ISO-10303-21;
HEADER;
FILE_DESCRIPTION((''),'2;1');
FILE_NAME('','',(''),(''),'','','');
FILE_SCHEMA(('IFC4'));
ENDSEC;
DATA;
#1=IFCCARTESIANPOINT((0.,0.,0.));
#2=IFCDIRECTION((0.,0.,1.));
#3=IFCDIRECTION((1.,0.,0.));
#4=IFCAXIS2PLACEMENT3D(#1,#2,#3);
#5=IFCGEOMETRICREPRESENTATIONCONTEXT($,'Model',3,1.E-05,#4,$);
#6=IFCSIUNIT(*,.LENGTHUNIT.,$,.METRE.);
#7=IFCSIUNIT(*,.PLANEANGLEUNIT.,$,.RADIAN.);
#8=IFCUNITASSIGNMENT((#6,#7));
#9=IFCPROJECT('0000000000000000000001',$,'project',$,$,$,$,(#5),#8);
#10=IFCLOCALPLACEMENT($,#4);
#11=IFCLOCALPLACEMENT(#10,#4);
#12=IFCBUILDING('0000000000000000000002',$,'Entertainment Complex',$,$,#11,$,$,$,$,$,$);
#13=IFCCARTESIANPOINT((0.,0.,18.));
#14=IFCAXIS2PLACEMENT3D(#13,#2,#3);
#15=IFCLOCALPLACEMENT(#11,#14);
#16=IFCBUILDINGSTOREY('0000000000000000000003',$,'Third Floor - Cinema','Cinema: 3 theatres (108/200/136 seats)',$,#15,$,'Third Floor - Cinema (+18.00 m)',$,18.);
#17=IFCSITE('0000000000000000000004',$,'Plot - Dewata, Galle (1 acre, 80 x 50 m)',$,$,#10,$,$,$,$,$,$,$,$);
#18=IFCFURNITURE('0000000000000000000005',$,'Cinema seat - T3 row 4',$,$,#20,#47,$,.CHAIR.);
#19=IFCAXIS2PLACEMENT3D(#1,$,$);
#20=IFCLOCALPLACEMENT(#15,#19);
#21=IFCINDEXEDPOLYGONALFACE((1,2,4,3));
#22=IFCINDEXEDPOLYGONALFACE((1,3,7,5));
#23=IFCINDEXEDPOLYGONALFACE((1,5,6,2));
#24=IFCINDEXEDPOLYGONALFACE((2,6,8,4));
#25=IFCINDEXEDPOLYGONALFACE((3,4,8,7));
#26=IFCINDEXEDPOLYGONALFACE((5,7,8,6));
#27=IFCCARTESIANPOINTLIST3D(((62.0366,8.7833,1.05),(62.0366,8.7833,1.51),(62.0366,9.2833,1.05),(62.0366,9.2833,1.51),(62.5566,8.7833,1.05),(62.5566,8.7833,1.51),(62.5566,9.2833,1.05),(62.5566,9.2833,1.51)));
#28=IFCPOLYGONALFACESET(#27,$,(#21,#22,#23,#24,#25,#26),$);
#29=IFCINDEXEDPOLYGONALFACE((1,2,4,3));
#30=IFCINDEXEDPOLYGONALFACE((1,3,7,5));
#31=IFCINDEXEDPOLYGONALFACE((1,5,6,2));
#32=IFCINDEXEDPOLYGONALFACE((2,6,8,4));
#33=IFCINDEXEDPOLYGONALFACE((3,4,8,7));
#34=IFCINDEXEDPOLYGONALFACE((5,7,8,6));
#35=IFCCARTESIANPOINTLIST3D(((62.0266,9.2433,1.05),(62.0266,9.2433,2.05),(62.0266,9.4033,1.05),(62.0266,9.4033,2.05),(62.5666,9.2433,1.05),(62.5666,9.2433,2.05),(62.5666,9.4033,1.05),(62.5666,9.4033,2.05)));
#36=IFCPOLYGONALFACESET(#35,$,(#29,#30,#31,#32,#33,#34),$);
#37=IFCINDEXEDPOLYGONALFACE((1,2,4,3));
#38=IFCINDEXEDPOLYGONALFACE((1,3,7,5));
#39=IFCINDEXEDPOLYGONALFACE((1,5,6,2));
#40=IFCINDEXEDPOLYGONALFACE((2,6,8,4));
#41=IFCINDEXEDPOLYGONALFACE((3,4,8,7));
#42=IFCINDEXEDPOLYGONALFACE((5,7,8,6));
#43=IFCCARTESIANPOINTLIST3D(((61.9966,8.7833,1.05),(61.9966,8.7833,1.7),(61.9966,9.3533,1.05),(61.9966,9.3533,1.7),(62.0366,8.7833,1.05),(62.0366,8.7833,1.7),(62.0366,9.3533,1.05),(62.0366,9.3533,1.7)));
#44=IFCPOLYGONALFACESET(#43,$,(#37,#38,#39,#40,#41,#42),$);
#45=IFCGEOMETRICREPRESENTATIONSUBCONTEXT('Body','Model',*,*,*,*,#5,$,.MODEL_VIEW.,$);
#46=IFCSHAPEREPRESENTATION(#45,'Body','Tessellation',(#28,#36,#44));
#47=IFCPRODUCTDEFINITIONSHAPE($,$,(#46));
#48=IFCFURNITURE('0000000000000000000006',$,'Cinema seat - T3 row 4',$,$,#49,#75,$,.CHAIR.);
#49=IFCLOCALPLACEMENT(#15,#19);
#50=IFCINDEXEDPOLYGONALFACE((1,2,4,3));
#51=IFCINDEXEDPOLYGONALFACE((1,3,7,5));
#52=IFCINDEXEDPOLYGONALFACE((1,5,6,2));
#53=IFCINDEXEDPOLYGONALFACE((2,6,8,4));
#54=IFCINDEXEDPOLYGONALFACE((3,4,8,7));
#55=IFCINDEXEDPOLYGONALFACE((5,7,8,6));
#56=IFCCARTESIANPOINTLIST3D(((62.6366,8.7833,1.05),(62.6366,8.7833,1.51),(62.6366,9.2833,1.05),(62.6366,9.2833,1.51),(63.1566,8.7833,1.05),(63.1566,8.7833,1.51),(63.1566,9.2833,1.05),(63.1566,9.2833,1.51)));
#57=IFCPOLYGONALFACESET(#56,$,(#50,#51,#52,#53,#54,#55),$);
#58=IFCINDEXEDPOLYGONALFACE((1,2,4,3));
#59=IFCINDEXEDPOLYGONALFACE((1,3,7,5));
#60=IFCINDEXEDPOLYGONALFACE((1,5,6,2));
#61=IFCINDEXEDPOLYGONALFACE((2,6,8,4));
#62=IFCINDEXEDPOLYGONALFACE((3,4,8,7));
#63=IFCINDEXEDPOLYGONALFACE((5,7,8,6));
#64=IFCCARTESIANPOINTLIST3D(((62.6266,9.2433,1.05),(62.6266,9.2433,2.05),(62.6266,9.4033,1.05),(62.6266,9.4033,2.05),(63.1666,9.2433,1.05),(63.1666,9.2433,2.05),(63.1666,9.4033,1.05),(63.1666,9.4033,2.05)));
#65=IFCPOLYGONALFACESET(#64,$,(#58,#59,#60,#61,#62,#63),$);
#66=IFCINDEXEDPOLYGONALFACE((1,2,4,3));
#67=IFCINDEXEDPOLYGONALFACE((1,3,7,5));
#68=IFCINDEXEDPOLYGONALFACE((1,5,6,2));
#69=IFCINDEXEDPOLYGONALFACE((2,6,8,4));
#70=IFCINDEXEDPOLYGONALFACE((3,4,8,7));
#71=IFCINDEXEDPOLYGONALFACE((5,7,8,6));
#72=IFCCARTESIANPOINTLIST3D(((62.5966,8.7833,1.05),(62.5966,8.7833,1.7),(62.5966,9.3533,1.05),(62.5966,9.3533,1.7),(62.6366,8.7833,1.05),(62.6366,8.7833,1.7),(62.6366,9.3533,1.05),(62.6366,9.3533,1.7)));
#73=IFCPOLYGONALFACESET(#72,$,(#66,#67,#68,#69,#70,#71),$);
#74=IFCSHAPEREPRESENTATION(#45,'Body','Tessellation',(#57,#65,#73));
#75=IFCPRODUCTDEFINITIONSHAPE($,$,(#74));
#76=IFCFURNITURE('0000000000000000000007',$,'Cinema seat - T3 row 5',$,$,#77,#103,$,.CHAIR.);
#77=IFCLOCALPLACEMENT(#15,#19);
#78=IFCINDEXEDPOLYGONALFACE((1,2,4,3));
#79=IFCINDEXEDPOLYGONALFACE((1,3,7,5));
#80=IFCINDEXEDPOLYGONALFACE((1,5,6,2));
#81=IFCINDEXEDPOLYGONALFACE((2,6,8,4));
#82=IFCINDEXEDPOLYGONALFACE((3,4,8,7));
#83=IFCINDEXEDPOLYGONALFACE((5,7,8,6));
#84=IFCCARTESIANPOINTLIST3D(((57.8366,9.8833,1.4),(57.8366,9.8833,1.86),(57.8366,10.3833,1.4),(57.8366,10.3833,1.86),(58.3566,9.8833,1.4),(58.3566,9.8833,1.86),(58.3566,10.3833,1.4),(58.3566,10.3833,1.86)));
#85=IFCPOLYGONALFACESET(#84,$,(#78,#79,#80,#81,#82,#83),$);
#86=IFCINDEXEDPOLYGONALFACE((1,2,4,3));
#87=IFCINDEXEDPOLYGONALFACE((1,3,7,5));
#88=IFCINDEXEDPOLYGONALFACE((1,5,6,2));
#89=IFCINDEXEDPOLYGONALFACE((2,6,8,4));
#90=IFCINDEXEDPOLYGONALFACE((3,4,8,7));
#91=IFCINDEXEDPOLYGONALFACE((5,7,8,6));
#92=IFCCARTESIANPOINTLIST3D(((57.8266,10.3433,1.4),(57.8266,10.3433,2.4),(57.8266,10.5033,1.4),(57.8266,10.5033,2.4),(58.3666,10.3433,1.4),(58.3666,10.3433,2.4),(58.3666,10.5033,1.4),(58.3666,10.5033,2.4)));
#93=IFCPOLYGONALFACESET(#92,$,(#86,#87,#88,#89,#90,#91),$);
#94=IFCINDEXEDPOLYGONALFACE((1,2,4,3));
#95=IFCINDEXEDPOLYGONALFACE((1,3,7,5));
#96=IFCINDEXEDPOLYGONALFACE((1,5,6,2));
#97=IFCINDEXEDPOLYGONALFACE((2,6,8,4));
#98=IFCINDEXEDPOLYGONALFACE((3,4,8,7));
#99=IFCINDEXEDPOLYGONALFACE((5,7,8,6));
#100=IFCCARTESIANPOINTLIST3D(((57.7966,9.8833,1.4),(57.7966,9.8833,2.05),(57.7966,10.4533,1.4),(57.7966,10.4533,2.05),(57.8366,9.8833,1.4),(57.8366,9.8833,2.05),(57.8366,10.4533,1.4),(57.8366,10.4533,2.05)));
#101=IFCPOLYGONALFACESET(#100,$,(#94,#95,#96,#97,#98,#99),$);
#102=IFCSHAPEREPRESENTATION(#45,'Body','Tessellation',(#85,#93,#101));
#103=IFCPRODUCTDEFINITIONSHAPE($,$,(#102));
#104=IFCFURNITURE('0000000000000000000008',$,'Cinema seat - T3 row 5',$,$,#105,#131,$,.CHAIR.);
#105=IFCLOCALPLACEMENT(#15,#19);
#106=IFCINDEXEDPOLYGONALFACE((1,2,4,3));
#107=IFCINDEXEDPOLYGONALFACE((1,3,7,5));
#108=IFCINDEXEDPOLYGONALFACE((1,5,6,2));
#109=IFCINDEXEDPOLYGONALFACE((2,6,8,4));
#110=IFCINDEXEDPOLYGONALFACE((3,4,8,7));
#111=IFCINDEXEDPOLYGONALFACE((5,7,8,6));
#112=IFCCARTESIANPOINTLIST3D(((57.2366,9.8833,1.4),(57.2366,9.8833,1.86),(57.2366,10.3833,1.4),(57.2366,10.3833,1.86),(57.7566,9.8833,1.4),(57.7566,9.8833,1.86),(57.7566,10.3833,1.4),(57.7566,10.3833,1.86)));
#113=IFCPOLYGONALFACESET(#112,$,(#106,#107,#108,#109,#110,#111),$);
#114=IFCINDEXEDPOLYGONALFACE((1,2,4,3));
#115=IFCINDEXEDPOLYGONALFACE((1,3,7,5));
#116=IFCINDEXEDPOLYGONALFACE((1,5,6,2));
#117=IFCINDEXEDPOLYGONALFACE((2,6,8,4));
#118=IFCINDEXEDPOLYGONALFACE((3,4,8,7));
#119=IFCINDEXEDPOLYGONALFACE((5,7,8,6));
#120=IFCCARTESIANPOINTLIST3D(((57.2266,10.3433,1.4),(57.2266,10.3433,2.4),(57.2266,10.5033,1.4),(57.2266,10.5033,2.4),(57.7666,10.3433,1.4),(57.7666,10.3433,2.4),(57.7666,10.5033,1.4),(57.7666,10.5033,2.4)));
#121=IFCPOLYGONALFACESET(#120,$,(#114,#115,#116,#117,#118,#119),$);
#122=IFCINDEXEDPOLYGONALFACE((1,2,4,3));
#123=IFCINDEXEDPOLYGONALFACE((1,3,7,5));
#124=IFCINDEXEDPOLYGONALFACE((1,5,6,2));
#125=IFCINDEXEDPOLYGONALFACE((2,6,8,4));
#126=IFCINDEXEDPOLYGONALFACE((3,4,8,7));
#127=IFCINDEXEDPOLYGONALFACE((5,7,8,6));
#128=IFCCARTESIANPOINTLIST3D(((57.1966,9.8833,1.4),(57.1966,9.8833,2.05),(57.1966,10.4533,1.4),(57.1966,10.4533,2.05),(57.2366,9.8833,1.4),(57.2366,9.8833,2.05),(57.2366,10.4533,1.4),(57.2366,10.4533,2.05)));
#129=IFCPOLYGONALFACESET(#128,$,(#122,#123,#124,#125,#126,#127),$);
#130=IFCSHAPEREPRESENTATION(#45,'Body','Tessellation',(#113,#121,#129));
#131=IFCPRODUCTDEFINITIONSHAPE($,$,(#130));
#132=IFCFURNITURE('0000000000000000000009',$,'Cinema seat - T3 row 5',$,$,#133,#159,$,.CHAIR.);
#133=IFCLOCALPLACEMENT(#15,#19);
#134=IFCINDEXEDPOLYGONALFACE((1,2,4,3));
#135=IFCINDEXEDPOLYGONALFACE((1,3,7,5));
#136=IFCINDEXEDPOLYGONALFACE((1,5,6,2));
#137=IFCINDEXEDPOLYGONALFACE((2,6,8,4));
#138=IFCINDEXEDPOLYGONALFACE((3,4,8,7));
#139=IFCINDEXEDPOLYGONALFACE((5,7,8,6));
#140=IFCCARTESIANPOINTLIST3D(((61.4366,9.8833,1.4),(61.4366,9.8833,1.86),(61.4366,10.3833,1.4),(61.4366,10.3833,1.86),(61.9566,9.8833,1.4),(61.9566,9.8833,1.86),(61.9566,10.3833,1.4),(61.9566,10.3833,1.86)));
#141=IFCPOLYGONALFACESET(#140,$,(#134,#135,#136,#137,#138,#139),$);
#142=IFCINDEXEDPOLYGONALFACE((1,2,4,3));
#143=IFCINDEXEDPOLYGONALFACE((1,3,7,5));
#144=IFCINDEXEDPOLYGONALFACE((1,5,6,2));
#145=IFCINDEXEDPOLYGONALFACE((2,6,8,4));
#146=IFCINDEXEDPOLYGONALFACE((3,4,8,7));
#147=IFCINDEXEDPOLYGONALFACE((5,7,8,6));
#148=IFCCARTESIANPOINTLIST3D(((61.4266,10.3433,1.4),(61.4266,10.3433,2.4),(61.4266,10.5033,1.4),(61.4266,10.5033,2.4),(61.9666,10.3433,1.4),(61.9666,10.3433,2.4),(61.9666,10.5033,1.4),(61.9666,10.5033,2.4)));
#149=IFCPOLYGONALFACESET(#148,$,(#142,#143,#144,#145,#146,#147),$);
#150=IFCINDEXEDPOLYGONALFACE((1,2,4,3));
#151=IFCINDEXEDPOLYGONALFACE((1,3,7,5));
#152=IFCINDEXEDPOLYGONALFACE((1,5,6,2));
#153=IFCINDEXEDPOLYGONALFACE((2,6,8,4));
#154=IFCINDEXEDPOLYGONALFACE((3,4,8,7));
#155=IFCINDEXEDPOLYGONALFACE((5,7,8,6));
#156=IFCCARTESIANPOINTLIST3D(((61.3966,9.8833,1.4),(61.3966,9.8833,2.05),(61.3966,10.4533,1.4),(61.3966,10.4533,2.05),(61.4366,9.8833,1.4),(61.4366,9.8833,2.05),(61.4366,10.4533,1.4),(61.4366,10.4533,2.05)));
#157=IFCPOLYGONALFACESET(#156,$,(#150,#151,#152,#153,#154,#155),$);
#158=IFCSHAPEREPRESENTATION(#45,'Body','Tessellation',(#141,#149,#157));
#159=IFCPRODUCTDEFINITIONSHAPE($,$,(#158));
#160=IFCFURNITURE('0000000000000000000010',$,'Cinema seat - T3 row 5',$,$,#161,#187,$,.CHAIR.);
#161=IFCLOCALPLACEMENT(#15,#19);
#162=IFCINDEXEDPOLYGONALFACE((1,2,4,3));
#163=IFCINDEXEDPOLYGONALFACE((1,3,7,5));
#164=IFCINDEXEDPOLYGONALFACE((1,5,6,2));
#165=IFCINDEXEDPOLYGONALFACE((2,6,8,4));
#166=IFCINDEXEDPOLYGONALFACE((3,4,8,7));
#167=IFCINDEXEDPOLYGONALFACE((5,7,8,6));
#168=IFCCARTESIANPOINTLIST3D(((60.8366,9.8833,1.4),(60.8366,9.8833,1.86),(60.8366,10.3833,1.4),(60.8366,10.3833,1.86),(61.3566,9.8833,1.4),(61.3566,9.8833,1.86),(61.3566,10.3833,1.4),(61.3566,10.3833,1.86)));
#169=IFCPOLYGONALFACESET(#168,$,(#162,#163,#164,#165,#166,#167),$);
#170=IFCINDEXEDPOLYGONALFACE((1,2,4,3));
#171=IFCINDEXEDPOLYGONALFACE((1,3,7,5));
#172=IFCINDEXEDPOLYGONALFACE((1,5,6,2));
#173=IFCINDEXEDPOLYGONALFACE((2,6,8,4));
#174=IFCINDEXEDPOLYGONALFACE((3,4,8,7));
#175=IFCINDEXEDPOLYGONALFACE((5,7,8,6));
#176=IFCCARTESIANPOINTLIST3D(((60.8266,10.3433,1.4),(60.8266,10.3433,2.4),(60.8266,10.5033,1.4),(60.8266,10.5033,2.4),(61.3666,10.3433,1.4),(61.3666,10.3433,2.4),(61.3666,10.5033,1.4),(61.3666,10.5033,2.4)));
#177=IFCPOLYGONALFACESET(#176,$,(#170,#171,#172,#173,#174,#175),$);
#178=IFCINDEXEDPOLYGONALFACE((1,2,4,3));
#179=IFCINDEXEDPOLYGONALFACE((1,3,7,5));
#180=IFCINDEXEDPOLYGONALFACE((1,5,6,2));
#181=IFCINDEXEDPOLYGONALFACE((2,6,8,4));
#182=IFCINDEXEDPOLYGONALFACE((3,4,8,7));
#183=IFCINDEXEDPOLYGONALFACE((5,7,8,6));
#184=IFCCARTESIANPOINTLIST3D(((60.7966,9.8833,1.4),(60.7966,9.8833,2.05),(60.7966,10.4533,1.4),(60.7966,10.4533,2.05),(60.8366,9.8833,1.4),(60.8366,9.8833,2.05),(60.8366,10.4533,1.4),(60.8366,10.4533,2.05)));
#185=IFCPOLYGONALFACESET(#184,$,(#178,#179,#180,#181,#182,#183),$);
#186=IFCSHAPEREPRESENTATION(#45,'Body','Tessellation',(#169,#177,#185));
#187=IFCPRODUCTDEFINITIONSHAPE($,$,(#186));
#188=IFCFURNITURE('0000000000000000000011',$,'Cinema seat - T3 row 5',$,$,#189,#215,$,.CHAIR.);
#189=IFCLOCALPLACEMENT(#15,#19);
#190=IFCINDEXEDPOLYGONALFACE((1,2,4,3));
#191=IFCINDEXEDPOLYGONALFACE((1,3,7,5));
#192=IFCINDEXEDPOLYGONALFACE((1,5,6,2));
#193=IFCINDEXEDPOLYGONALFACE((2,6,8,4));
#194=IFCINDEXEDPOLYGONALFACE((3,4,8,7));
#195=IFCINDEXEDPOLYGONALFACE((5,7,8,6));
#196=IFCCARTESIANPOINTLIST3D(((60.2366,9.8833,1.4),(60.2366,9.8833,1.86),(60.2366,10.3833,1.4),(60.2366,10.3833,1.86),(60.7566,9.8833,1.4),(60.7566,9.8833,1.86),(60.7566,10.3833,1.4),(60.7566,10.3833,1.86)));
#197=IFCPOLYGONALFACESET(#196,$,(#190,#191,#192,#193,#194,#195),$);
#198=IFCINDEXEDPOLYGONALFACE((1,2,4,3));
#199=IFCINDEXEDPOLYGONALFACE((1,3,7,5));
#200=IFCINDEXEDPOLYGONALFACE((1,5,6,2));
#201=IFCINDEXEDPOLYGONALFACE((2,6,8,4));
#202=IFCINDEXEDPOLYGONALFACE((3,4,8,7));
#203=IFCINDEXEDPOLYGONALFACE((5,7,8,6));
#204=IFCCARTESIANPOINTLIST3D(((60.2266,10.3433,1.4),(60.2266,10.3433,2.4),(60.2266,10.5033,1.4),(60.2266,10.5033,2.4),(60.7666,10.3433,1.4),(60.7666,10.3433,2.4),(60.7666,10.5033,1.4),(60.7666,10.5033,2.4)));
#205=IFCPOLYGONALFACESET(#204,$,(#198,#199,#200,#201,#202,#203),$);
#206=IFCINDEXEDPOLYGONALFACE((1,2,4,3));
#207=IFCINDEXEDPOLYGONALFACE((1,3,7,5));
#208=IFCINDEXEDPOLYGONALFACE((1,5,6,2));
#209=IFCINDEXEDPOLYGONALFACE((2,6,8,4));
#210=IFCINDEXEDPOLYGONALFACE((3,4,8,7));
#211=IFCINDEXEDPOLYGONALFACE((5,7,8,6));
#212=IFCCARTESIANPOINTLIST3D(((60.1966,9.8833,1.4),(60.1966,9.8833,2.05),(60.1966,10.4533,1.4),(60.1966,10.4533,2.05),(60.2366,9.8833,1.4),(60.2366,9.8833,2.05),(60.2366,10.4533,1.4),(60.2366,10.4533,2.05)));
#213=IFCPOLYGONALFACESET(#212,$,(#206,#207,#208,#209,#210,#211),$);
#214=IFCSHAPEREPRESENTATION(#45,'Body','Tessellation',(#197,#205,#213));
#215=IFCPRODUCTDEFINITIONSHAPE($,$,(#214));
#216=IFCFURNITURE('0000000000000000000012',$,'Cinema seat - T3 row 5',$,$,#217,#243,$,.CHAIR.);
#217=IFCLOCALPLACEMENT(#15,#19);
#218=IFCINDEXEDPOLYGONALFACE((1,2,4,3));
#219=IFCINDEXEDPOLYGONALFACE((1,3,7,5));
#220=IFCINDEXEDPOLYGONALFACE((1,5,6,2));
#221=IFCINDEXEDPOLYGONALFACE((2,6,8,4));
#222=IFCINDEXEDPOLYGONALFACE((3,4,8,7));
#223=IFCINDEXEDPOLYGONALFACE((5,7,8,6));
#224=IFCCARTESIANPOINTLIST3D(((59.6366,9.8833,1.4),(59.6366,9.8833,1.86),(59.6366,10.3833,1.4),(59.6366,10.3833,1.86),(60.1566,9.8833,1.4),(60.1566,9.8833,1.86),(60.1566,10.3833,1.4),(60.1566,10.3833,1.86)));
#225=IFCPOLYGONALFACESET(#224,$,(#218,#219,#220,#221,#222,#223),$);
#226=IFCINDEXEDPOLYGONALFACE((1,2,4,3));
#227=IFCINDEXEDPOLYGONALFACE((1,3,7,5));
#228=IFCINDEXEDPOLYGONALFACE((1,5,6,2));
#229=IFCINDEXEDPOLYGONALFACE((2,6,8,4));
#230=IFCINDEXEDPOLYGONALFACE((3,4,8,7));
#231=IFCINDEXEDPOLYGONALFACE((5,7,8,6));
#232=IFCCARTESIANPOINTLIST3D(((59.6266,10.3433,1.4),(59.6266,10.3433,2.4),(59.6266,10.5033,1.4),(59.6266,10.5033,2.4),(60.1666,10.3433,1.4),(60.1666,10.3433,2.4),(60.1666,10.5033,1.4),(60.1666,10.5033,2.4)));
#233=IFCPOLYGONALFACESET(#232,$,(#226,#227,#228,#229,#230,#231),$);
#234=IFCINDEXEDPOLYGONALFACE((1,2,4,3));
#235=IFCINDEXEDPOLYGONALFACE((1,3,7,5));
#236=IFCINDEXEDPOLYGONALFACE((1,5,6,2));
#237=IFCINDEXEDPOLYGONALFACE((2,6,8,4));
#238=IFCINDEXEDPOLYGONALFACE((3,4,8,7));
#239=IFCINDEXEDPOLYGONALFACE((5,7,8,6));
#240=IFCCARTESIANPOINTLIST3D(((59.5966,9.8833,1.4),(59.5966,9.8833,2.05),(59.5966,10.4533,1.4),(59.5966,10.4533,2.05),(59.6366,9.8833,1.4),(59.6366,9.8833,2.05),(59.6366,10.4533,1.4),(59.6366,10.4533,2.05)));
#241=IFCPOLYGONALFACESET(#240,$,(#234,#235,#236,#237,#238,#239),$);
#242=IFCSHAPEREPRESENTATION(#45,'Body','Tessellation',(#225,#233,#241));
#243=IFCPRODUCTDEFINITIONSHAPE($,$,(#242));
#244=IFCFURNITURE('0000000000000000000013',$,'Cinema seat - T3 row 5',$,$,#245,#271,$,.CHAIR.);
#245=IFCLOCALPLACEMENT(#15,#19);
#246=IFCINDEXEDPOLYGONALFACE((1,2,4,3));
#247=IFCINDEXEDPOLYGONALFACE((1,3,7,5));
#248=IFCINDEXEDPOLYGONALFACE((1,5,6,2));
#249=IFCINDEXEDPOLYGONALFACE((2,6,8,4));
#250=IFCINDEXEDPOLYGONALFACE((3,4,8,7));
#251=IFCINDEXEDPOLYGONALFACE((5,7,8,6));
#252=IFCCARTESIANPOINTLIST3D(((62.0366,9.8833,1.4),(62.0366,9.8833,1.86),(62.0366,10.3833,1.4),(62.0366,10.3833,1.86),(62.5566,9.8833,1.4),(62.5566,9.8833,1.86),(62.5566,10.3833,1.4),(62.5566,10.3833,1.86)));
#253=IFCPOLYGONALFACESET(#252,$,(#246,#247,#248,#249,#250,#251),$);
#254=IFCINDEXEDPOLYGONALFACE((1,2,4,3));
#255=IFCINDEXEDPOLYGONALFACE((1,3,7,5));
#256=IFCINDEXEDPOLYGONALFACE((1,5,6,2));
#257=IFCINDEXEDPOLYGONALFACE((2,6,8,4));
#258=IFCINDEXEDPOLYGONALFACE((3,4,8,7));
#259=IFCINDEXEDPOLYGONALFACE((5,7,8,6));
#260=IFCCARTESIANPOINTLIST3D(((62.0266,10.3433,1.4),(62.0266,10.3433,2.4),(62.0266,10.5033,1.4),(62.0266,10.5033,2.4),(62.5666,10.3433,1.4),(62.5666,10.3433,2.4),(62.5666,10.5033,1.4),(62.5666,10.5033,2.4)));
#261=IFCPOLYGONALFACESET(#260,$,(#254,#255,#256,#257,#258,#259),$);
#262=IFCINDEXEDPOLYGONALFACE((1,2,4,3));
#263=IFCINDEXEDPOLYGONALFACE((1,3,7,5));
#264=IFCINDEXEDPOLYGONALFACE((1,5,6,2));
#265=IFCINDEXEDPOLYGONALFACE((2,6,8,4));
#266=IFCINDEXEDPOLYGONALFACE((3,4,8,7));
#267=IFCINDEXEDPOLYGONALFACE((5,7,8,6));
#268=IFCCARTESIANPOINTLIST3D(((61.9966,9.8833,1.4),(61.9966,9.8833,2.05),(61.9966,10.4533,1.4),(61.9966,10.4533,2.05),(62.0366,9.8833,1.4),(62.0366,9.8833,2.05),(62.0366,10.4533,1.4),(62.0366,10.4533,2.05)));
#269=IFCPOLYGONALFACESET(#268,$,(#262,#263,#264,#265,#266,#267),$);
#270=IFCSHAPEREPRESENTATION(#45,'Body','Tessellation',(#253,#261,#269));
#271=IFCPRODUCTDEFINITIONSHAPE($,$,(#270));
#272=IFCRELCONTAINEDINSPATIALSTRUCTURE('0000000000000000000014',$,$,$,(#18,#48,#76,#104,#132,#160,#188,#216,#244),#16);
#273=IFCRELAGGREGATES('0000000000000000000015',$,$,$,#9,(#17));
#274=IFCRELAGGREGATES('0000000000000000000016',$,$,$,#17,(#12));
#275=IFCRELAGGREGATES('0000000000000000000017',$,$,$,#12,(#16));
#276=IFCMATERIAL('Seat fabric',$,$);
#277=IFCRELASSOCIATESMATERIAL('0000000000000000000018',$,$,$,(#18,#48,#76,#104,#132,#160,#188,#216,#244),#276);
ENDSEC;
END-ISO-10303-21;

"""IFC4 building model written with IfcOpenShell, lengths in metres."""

from ifc_helpers import new_model, si_unit, frame, origin_with_axes, place, context, subcontext, project, spatial, polyline, outline, extrude, material, element, save


model = new_model("IFC4")

# Units and contexts
model_context = context("Model", 3, precision=1e-05, world=origin_with_axes())
body_context = subcontext(model_context, "Body", "Model", "MODEL_VIEW")
ifc_project = project(units=[si_unit("LENGTHUNIT", "METRE"), si_unit("PLANEANGLEUNIT", "RADIAN")], contexts=[model_context])

# Site, building, storey
site_placement = place(None, origin_with_axes())
site = spatial("IfcSite", under=ifc_project, at=site_placement, Name="Plot - Dewata, Galle (1 acre, 80 x 50 m)")
building_placement = place(site_placement, origin_with_axes())
building = spatial("IfcBuilding", under=site, at=building_placement, Name="Entertainment Complex")
storey_placement = place(building_placement, frame((0.0, 0.0, 18.0), z_axis=(0.0, 0.0, 1.0), x_axis=(1.0, 0.0, 0.0)))
storey = spatial("IfcBuildingStorey", under=building, at=storey_placement, Name="Third Floor - Cinema", Description="Cinema: 3 theatres (108/200/136 seats)", LongName="Third Floor - Cinema (+18.00 m)", Elevation=18.0)

# Furniture
ifc_material_1 = material(Name="Seat fabric")
for number, where, z_axis, x_axis, name in (
    (1, (62.2966, 9.4033, 1.05), (0.0, 0.0, 1.0), (0.0, 1.0, 0.0), "Cinema seat - T3 row 4"),
    (2, (62.8966, 9.4033, 1.05), (0.0, 0.0, 1.0), (0.0, 1.0, 0.0), "Cinema seat - T3 row 4"),
    (3, (58.0966, 10.5033, 1.4), (0.0, 0.0, 1.0), (0.0, 1.0, 0.0), "Cinema seat - T3 row 5"),
    (4, (57.4966, 10.5033, 1.4), (0.0, 0.0, 1.0), (0.0, 1.0, 0.0), "Cinema seat - T3 row 5"),
    (5, (61.6966, 10.5033, 1.4), (0.0, 0.0, 1.0), (0.0, 1.0, 0.0), "Cinema seat - T3 row 5"),
    (6, (61.0966, 10.5033, 1.4), (0.0, 0.0, 1.0), (0.0, 1.0, 0.0), "Cinema seat - T3 row 5"),
    (7, (60.4966, 10.5033, 1.4), (0.0, 0.0, 1.0), (0.0, 1.0, 0.0), "Cinema seat - T3 row 5"),
    (8, (59.8966, 10.5033, 1.4), (0.0, 0.0, 1.0), (0.0, 1.0, 0.0), "Cinema seat - T3 row 5"),
    (9, (62.2966, 10.5033, 1.4), (0.0, 0.0, 1.0), (0.0, 1.0, 0.0), "Cinema seat - T3 row 5"),
):
    element("IfcFurniture", number, at=place(storey_placement, frame(where, z_axis=z_axis, x_axis=x_axis)), inside=storey, material=ifc_material_1, Name=name, PredefinedType="CHAIR", context=body_context, shape_type="SweptSolid", body=[
        extrude(outline(polyline([(-0.62, -0.26), (-0.12, -0.26), (-0.12, 0.26), (-0.62, 0.26), (-0.62, -0.26)])), origin_with_axes(), (0.0, 0.0, 1.0), 0.46),
        extrude(outline(polyline([(-0.16, -0.27), (0.0, -0.27), (0.0, 0.27), (-0.16, 0.27), (-0.16, -0.27)])), origin_with_axes(), (0.0, 0.0, 1.0), 1.0),
        extrude(outline(polyline([(-0.62, 0.26), (-0.05, 0.26), (-0.05, 0.3), (-0.62, 0.3), (-0.62, 0.26)])), origin_with_axes(), (0.0, 0.0, 1.0), 0.65),
    ])

save(model, "model.ifc")
